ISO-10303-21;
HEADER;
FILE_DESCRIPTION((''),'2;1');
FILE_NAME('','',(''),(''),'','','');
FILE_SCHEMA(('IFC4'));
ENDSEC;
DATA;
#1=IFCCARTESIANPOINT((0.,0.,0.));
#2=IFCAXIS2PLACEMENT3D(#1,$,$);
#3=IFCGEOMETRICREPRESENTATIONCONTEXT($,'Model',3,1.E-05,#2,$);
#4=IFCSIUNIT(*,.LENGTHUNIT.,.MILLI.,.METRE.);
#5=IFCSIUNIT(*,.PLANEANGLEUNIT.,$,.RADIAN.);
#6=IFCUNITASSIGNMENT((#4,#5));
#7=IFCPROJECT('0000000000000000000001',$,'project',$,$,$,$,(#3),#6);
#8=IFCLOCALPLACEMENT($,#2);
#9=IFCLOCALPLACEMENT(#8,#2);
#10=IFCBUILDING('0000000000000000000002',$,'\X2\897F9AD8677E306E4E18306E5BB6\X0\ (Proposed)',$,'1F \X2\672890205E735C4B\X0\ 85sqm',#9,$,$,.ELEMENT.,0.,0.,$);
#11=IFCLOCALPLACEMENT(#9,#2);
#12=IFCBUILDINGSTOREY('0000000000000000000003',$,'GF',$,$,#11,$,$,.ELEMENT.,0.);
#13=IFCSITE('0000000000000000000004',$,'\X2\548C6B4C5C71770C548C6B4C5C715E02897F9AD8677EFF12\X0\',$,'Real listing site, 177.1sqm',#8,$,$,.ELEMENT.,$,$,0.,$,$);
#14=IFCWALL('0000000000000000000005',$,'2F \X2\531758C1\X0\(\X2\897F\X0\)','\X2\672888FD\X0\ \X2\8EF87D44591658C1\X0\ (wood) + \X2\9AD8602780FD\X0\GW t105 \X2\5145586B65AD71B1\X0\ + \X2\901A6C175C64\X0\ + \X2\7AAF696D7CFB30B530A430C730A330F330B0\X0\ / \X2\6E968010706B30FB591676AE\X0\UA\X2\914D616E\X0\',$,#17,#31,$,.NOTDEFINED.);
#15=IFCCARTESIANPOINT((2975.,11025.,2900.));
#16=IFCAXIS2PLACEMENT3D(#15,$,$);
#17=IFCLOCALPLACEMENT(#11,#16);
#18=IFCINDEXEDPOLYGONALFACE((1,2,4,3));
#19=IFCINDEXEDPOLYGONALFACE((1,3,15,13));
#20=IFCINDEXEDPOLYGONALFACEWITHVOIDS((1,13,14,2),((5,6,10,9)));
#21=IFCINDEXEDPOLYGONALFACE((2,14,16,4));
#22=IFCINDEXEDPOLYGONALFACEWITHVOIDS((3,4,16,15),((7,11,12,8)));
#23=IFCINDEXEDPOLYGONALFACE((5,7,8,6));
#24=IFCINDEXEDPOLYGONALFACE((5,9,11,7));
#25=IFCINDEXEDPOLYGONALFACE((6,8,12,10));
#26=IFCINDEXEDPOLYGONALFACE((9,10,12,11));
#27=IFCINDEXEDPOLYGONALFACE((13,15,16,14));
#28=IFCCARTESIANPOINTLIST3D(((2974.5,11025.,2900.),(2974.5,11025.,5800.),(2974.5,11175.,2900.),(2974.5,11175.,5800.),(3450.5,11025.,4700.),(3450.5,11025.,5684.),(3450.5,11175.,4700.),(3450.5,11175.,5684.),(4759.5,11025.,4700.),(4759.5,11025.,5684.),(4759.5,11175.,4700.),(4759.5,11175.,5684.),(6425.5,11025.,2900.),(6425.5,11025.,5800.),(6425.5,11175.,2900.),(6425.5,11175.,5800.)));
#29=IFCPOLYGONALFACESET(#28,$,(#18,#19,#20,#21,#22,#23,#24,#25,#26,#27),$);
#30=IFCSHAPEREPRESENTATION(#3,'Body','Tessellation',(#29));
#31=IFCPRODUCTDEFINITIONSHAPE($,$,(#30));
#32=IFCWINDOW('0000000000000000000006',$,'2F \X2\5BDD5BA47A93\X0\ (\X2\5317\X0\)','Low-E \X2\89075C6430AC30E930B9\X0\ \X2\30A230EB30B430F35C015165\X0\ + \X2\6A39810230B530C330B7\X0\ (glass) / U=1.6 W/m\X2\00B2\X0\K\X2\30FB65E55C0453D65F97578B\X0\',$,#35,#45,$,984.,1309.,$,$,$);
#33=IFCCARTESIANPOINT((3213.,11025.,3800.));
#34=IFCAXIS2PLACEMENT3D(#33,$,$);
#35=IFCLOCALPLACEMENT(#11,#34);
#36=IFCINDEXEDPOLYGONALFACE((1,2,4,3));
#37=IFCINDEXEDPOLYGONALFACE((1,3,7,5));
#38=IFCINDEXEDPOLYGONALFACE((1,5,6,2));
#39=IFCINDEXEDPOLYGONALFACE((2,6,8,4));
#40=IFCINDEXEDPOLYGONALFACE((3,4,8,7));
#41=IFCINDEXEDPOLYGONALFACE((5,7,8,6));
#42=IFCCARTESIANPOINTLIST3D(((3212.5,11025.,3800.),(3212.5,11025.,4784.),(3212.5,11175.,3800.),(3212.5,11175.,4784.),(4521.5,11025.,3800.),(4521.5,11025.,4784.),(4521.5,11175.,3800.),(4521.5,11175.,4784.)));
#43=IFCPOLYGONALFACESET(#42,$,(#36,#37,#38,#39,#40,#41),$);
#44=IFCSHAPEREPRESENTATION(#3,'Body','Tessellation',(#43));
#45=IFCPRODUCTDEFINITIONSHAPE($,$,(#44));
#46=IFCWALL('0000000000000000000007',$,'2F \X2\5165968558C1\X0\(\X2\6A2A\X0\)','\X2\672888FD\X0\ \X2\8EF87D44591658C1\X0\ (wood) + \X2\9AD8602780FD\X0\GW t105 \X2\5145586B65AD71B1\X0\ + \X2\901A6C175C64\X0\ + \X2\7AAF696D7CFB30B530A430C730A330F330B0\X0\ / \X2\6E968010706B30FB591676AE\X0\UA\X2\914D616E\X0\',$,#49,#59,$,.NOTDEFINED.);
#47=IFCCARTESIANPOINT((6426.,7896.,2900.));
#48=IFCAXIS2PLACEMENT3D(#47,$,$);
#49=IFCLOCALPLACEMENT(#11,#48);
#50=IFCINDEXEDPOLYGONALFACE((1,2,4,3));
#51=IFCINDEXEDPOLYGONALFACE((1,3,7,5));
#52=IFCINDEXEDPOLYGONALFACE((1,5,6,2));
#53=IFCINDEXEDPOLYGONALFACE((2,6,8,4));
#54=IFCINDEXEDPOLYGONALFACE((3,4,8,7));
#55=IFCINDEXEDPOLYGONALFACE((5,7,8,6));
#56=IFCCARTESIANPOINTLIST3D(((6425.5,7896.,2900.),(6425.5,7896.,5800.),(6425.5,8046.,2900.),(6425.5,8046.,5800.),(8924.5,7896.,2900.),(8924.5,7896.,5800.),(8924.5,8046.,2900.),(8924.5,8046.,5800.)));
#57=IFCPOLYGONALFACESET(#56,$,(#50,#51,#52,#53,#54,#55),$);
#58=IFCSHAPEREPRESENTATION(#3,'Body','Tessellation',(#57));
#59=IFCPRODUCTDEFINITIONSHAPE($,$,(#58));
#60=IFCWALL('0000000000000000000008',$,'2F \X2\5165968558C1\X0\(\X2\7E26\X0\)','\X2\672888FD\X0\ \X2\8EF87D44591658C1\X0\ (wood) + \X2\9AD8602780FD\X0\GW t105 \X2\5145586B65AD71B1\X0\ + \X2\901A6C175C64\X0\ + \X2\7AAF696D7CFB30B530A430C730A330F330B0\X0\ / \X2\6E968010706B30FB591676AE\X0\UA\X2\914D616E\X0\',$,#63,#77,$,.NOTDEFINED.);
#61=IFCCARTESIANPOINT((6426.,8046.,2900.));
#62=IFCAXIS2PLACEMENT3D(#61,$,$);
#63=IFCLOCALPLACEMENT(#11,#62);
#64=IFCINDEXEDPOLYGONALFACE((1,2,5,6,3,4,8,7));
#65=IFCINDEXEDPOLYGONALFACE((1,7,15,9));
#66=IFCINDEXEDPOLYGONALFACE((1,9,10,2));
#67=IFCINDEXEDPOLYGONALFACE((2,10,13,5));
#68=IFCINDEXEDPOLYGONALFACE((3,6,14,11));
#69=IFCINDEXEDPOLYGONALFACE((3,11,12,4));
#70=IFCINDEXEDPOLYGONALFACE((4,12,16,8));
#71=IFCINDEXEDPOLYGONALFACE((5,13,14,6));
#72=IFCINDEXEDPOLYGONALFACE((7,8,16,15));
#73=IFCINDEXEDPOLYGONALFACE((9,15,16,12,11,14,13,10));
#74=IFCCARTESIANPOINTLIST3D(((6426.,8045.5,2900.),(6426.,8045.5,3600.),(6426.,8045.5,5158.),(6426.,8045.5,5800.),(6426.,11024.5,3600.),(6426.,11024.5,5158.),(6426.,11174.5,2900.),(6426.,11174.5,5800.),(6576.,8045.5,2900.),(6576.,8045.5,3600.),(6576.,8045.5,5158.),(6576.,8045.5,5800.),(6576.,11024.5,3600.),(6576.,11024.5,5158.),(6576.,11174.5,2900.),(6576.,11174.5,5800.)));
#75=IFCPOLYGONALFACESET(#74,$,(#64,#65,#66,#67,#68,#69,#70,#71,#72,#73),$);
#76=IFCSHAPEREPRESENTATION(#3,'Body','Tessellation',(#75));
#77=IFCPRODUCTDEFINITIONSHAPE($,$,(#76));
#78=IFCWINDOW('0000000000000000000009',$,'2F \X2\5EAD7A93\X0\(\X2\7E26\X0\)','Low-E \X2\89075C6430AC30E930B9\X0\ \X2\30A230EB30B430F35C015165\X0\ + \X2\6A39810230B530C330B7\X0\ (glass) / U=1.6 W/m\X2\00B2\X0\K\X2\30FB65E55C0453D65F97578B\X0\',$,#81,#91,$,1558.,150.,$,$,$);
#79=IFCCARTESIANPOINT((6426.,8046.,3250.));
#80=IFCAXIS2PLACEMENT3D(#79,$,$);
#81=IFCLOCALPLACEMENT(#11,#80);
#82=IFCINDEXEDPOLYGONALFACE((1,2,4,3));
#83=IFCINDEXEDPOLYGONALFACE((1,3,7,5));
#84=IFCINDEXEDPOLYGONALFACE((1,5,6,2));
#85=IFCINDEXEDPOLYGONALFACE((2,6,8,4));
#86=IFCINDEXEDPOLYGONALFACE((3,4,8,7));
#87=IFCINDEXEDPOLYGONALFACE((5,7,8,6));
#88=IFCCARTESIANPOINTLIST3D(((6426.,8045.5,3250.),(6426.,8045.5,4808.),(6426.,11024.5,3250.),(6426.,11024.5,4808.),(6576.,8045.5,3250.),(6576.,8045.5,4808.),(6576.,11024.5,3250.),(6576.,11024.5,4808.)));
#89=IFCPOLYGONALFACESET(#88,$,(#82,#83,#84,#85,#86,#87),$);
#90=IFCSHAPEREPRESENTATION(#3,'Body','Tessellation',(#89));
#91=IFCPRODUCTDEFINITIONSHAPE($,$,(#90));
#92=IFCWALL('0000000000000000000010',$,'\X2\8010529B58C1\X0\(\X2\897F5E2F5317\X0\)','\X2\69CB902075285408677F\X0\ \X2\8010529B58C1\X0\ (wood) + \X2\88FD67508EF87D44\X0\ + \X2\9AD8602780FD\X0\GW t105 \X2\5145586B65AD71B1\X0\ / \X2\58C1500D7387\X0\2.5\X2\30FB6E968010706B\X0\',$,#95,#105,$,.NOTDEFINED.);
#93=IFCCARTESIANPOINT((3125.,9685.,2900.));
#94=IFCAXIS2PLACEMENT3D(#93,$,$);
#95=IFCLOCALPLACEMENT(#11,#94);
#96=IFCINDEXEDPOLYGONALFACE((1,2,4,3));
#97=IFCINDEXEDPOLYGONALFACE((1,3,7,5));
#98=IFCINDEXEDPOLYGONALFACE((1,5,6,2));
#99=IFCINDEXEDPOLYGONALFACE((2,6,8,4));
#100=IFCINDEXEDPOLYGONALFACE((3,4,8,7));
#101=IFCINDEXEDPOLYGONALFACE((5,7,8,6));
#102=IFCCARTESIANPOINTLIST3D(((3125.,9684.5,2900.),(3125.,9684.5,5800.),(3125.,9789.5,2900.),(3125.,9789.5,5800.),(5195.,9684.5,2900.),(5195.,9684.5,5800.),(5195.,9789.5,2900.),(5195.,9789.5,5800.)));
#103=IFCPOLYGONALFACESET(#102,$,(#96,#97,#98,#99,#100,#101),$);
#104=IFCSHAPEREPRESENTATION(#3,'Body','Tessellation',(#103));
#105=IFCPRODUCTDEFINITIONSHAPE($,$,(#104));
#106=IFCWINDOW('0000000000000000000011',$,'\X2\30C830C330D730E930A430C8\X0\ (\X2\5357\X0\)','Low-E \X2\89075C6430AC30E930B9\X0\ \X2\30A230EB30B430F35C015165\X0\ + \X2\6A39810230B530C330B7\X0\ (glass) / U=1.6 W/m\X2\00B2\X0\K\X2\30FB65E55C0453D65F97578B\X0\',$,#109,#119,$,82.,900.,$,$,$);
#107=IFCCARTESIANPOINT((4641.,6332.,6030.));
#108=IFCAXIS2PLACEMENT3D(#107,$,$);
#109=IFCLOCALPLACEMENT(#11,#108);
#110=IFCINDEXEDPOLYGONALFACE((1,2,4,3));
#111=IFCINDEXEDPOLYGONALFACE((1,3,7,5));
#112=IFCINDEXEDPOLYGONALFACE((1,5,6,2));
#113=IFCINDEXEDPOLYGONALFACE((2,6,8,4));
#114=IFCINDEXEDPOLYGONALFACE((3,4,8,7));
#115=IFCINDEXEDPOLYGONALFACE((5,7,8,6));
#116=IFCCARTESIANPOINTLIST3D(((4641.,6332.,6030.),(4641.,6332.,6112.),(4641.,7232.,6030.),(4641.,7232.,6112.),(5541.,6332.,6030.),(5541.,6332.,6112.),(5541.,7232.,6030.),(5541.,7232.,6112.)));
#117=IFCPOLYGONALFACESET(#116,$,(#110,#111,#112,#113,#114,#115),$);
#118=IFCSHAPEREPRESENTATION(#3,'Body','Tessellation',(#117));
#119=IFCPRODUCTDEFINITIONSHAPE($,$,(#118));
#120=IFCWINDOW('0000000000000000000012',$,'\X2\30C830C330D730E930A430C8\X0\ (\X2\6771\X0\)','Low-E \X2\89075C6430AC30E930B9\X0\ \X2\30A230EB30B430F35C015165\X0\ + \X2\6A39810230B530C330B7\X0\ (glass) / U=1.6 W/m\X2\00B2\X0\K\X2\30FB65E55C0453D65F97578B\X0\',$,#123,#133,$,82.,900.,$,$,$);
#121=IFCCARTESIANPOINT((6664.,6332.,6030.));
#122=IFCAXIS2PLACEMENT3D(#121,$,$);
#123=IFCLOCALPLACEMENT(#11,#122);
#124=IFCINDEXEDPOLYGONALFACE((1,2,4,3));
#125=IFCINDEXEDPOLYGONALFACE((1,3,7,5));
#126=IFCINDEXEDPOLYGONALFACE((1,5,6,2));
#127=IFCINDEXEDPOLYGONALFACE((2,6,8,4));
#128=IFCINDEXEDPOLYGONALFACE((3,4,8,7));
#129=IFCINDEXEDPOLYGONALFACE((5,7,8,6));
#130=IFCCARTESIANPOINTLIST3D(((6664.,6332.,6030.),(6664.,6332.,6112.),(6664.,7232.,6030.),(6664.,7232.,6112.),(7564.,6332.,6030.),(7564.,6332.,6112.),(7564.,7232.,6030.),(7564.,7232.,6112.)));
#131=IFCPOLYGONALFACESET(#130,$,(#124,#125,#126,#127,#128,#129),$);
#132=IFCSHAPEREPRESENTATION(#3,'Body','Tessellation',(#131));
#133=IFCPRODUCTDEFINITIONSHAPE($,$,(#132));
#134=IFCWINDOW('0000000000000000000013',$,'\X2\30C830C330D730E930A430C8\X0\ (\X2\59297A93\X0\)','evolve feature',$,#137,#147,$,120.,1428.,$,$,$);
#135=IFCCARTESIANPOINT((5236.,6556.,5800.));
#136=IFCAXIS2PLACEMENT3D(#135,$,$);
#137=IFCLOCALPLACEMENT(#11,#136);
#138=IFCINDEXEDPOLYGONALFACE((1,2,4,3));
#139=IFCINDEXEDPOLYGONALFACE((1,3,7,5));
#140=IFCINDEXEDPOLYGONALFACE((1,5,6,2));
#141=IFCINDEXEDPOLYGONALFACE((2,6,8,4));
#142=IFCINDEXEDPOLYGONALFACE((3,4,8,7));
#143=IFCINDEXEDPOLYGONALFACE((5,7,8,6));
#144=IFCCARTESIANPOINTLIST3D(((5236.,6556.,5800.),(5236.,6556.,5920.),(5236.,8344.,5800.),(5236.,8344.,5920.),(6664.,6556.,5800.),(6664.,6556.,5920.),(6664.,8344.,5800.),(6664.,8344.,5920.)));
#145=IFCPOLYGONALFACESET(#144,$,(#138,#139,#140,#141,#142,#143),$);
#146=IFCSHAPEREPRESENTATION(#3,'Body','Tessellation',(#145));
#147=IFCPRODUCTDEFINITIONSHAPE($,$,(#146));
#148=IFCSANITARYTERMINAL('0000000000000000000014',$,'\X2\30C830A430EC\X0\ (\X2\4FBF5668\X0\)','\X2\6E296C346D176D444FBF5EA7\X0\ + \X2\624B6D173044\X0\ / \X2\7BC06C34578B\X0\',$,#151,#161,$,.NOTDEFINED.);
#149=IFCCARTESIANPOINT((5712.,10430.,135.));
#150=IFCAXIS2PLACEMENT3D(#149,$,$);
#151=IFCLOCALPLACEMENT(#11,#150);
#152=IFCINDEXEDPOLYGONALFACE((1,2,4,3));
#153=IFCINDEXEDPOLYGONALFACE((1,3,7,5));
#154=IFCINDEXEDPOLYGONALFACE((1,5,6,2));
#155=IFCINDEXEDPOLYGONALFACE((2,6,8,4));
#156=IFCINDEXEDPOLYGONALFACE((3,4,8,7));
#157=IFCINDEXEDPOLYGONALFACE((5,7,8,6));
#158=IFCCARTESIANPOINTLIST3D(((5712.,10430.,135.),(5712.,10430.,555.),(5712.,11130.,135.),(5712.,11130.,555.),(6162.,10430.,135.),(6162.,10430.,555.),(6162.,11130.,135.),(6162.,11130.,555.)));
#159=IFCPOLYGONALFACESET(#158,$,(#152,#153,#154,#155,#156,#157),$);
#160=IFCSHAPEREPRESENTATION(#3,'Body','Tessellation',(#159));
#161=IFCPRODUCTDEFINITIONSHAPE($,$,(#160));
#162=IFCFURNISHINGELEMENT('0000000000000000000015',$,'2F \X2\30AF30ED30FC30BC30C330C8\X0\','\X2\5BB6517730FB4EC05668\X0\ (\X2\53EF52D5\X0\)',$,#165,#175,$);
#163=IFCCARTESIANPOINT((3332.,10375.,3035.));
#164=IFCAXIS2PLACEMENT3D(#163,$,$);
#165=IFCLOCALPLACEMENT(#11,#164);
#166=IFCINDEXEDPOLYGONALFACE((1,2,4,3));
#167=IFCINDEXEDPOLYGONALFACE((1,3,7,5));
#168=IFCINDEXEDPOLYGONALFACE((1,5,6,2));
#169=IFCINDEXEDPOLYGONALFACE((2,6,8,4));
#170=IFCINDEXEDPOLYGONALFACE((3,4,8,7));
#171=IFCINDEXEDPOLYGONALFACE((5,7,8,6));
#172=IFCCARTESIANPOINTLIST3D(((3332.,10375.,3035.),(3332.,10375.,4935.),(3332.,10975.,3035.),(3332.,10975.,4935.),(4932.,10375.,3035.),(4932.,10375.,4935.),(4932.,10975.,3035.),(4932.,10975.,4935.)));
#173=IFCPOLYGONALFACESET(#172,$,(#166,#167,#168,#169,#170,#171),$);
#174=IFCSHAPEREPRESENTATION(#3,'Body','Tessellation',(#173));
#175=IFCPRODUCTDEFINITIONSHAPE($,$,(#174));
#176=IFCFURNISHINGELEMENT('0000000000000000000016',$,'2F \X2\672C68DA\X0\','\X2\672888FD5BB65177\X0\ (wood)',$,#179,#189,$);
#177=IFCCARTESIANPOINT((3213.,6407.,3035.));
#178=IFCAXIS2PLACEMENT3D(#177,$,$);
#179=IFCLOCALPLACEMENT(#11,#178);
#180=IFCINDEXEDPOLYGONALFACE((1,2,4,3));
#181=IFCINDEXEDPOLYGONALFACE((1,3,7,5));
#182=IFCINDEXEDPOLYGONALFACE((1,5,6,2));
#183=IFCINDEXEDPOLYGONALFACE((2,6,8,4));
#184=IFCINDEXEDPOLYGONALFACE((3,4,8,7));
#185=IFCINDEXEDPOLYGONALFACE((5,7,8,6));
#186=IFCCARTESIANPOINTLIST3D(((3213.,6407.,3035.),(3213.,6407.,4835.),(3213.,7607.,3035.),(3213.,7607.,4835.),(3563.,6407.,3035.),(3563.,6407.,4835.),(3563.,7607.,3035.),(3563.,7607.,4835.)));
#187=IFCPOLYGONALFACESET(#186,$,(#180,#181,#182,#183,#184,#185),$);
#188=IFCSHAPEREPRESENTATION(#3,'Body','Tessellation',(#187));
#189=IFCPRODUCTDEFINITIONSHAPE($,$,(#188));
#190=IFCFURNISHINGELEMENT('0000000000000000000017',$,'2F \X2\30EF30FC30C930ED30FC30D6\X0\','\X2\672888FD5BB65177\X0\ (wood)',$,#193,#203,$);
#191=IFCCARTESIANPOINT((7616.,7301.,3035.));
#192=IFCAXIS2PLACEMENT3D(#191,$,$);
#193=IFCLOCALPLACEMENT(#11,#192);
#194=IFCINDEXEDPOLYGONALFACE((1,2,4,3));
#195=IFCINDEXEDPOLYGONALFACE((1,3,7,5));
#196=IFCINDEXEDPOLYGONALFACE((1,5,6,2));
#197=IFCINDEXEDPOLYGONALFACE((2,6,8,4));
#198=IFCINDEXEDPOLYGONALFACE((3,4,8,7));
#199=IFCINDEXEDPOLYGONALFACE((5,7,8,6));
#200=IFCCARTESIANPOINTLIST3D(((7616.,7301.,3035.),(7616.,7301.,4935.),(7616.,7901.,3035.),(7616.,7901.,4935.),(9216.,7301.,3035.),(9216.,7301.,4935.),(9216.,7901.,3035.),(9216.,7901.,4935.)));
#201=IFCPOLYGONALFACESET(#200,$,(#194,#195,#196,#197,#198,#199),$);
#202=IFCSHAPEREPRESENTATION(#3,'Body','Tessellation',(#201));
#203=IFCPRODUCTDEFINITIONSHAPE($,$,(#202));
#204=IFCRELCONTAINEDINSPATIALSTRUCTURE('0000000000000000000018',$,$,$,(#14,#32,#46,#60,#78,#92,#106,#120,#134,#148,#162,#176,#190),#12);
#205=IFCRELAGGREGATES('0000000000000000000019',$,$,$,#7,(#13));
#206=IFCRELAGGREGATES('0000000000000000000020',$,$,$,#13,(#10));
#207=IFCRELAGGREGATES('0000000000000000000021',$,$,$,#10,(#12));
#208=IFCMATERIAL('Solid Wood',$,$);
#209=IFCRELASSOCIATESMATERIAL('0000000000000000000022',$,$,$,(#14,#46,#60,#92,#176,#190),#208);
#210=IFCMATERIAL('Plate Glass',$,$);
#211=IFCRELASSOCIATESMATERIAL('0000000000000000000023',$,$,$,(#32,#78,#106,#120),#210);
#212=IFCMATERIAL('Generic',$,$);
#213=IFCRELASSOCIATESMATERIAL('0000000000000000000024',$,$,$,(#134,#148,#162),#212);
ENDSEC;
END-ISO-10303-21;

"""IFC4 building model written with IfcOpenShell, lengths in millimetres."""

from ifc_helpers import new_model, si_unit, frame, frame_2d, origin, place, context, project, spatial, rectangle, extrude, material, element, fill, save


model = new_model("IFC4")

# Units and contexts
model_context = context("Model", 3, precision=1e-05, world=origin())
ifc_project = project(units=[si_unit("LENGTHUNIT", "METRE", prefix="MILLI"), si_unit("PLANEANGLEUNIT", "RADIAN")], contexts=[model_context])

# Site, building, storey
site_placement = place(None, origin())
site = spatial("IfcSite", under=ifc_project, at=site_placement, Name="和歌山県和歌山市西高松２", ObjectType="Real listing site, 177.1sqm", CompositionType="ELEMENT", RefElevation=0.0)
building_placement = place(site_placement, origin())
building = spatial("IfcBuilding", under=site, at=building_placement, Name="西高松の丘の家 (Proposed)", ObjectType="1F 木造平屋 85sqm", CompositionType="ELEMENT", ElevationOfRefHeight=0.0, ElevationOfTerrain=0.0)
storey_placement = place(building_placement, origin())
storey = spatial("IfcBuildingStorey", under=building, at=storey_placement, Name="GF", CompositionType="ELEMENT", Elevation=0.0)

# Shared definitions
ifc_material_1 = material(Name="Solid Wood")

# Wall, opening, window
wall_1_placement = place(storey_placement, frame((2975.0, 11025.0, 2900.0)))
wall_1 = element("IfcWall", 1, at=wall_1_placement, inside=storey, material=ifc_material_1, Name="2F 北壁(西)", Description="木製 軸組外壁 (wood) + 高性能GW t105 充填断熱 + 通気層 + 窯業系サイディング / 準耐火・外皮UA配慮", PredefinedType="NOTDEFINED", context=model_context, shape_type="SweptSolid", body=[
    extrude(rectangle(XDim=3451.0, YDim=150.0, at=frame_2d((1725.0, 75.0))), frame((2975.0, 11025.0, 2900.0)), (0.0, 0.0, 1.0), 2900.0),
])
opening_1_placement = place(storey_placement, frame((3213.0, 11025.0, 3800.0)))
opening_1 = element("IfcOpeningElement", 2, at=opening_1_placement, cuts=wall_1, PredefinedType="NOTDEFINED", context=model_context, shape_type="SweptSolid", body=[
    extrude(rectangle(XDim=1309.0, YDim=150.0, at=frame_2d((654.0, 75.0))), frame((3213.0, 11025.0, 3800.0)), (0.0, 0.0, 1.0), 984.0),
])
ifc_material_2 = material(Name="Plate Glass")
window_1_placement = place(storey_placement, frame((3213.0, 11025.0, 3800.0)))
window_1 = element("IfcWindow", 3, at=window_1_placement, inside=storey, material=ifc_material_2, Name="2F 寝室窓 (北)", Description="Low-E 複層ガラス アルゴン封入 + 樹脂サッシ (glass) / U=1.6 W/m²K・日射取得型", OverallHeight=984.0, OverallWidth=1309.0, context=model_context, shape_type="SweptSolid", body=[
    extrude(rectangle(XDim=1309.0, YDim=150.0, at=frame_2d((654.0, 75.0))), frame((3213.0, 11025.0, 3800.0)), (0.0, 0.0, 1.0), 984.0),
])
fill(opening_1, window_1)

# Wall
wall_2_placement = place(storey_placement, frame((6426.0, 7896.0, 2900.0)))
element("IfcWall", 4, at=wall_2_placement, inside=storey, material=ifc_material_1, Name="2F 入隅壁(横)", Description="木製 軸組外壁 (wood) + 高性能GW t105 充填断熱 + 通気層 + 窯業系サイディング / 準耐火・外皮UA配慮", PredefinedType="NOTDEFINED", context=model_context, shape_type="SweptSolid", body=[
    extrude(rectangle(XDim=2499.0, YDim=150.0, at=frame_2d((1249.0, 75.0))), frame((6426.0, 7896.0, 2900.0)), (0.0, 0.0, 1.0), 2900.0),
])

# Wall, opening, window
wall_3_placement = place(storey_placement, frame((6426.0, 8046.0, 2900.0)))
wall_3 = element("IfcWall", 5, at=wall_3_placement, inside=storey, material=ifc_material_1, Name="2F 入隅壁(縦)", Description="木製 軸組外壁 (wood) + 高性能GW t105 充填断熱 + 通気層 + 窯業系サイディング / 準耐火・外皮UA配慮", PredefinedType="NOTDEFINED", context=model_context, shape_type="SweptSolid", body=[
    extrude(rectangle(XDim=150.0, YDim=3129.0, at=frame_2d((75.0, 1564.0))), frame((6426.0, 8046.0, 2900.0)), (0.0, 0.0, 1.0), 2900.0),
])
opening_2_placement = place(storey_placement, frame((6426.0, 8046.0, 3250.0)))
opening_2 = element("IfcOpeningElement", 6, at=opening_2_placement, cuts=wall_3, PredefinedType="NOTDEFINED", context=model_context, shape_type="SweptSolid", body=[
    extrude(rectangle(XDim=150.0, YDim=2979.0, at=frame_2d((75.0, 1489.0))), frame((6426.0, 8046.0, 3250.0)), (0.0, 0.0, 1.0), 1558.0),
])
window_2_placement = place(storey_placement, frame((6426.0, 8046.0, 3250.0)))
window_2 = element("IfcWindow", 7, at=window_2_placement, inside=storey, material=ifc_material_2, Name="2F 庭窓(縦)", Description="Low-E 複層ガラス アルゴン封入 + 樹脂サッシ (glass) / U=1.6 W/m²K・日射取得型", OverallHeight=1558.0, OverallWidth=150.0, context=model_context, shape_type="SweptSolid", body=[
    extrude(rectangle(XDim=150.0, YDim=2979.0, at=frame_2d((75.0, 1489.0))), frame((6426.0, 8046.0, 3250.0)), (0.0, 0.0, 1.0), 1558.0),
])
fill(opening_2, window_2)

# Wall
wall_4_placement = place(storey_placement, frame((3125.0, 9685.0, 2900.0)))
element("IfcWall", 8, at=wall_4_placement, inside=storey, material=ifc_material_1, Name="耐力壁(西帯北)", Description="構造用合板 耐力壁 (wood) + 製材軸組 + 高性能GW t105 充填断熱 / 壁倍率2.5・準耐火", PredefinedType="NOTDEFINED", context=model_context, shape_type="SweptSolid", body=[
    extrude(rectangle(XDim=2070.0, YDim=105.0, at=frame_2d((1035.0, 52.0))), frame((3125.0, 9685.0, 2900.0)), (0.0, 0.0, 1.0), 2900.0),
])

# Windows
window_3_placement = place(storey_placement, frame((4641.0, 6332.0, 6030.0)))
element("IfcWindow", 9, at=window_3_placement, inside=storey, material=ifc_material_2, Name="トップライト (南)", Description="Low-E 複層ガラス アルゴン封入 + 樹脂サッシ (glass) / U=1.6 W/m²K・日射取得型", OverallHeight=82.0, OverallWidth=900.0, context=model_context, shape_type="SweptSolid", body=[
    extrude(rectangle(XDim=900.0, YDim=900.0, at=frame_2d((450.0, 450.0))), frame((4641.0, 6332.0, 6030.0)), (0.0, 0.0, 1.0), 82.0),
])
window_4_placement = place(storey_placement, frame((6664.0, 6332.0, 6030.0)))
element("IfcWindow", 10, at=window_4_placement, inside=storey, material=ifc_material_2, Name="トップライト (東)", Description="Low-E 複層ガラス アルゴン封入 + 樹脂サッシ (glass) / U=1.6 W/m²K・日射取得型", OverallHeight=82.0, OverallWidth=900.0, context=model_context, shape_type="SweptSolid", body=[
    extrude(rectangle(XDim=900.0, YDim=900.0, at=frame_2d((450.0, 450.0))), frame((6664.0, 6332.0, 6030.0)), (0.0, 0.0, 1.0), 82.0),
])
ifc_material_3 = material(Name="Generic")
window_5_placement = place(storey_placement, frame((5236.0, 6556.0, 5800.0)))
element("IfcWindow", 11, at=window_5_placement, inside=storey, material=ifc_material_3, Name="トップライト (天窓)", Description="evolve feature", OverallHeight=120.0, OverallWidth=1428.0, context=model_context, shape_type="SweptSolid", body=[
    extrude(rectangle(XDim=1428.0, YDim=1788.0, at=frame_2d((714.0, 894.0))), frame((5236.0, 6556.0, 5800.0)), (0.0, 0.0, 1.0), 120.0),
])

# Sanitary terminal
sanitary_terminal_placement = place(storey_placement, frame((5712.0, 10430.0, 135.0)))
element("IfcSanitaryTerminal", 12, at=sanitary_terminal_placement, inside=storey, material=ifc_material_3, Name="トイレ (便器)", Description="温水洗浄便座 + 手洗い / 節水型", PredefinedType="NOTDEFINED", context=model_context, shape_type="SweptSolid", body=[
    extrude(rectangle(XDim=450.0, YDim=700.0, at=frame_2d((225.0, 350.0))), frame((5712.0, 10430.0, 135.0)), (0.0, 0.0, 1.0), 420.0),
])

# Furnishing elements
furnishing_1_placement = place(storey_placement, frame((3332.0, 10375.0, 3035.0)))
element("IfcFurnishingElement", 13, at=furnishing_1_placement, inside=storey, material=ifc_material_3, Name="2F クローゼット", Description="家具・什器 (可動)", context=model_context, shape_type="SweptSolid", body=[
    extrude(rectangle(XDim=1600.0, YDim=600.0, at=frame_2d((800.0, 300.0))), frame((3332.0, 10375.0, 3035.0)), (0.0, 0.0, 1.0), 1900.0),
])
furnishing_2_placement = place(storey_placement, frame((3213.0, 6407.0, 3035.0)))
element("IfcFurnishingElement", 14, at=furnishing_2_placement, inside=storey, material=ifc_material_1, Name="2F 本棚", Description="木製家具 (wood)", context=model_context, shape_type="SweptSolid", body=[
    extrude(rectangle(XDim=350.0, YDim=1200.0, at=frame_2d((175.0, 600.0))), frame((3213.0, 6407.0, 3035.0)), (0.0, 0.0, 1.0), 1800.0),
])
furnishing_3_placement = place(storey_placement, frame((7616.0, 7301.0, 3035.0)))
element("IfcFurnishingElement", 15, at=furnishing_3_placement, inside=storey, material=ifc_material_1, Name="2F ワードローブ", Description="木製家具 (wood)", context=model_context, shape_type="SweptSolid", body=[
    extrude(rectangle(XDim=1600.0, YDim=600.0, at=frame_2d((800.0, 300.0))), frame((7616.0, 7301.0, 3035.0)), (0.0, 0.0, 1.0), 1900.0),
])

save(model, "model.ifc")
